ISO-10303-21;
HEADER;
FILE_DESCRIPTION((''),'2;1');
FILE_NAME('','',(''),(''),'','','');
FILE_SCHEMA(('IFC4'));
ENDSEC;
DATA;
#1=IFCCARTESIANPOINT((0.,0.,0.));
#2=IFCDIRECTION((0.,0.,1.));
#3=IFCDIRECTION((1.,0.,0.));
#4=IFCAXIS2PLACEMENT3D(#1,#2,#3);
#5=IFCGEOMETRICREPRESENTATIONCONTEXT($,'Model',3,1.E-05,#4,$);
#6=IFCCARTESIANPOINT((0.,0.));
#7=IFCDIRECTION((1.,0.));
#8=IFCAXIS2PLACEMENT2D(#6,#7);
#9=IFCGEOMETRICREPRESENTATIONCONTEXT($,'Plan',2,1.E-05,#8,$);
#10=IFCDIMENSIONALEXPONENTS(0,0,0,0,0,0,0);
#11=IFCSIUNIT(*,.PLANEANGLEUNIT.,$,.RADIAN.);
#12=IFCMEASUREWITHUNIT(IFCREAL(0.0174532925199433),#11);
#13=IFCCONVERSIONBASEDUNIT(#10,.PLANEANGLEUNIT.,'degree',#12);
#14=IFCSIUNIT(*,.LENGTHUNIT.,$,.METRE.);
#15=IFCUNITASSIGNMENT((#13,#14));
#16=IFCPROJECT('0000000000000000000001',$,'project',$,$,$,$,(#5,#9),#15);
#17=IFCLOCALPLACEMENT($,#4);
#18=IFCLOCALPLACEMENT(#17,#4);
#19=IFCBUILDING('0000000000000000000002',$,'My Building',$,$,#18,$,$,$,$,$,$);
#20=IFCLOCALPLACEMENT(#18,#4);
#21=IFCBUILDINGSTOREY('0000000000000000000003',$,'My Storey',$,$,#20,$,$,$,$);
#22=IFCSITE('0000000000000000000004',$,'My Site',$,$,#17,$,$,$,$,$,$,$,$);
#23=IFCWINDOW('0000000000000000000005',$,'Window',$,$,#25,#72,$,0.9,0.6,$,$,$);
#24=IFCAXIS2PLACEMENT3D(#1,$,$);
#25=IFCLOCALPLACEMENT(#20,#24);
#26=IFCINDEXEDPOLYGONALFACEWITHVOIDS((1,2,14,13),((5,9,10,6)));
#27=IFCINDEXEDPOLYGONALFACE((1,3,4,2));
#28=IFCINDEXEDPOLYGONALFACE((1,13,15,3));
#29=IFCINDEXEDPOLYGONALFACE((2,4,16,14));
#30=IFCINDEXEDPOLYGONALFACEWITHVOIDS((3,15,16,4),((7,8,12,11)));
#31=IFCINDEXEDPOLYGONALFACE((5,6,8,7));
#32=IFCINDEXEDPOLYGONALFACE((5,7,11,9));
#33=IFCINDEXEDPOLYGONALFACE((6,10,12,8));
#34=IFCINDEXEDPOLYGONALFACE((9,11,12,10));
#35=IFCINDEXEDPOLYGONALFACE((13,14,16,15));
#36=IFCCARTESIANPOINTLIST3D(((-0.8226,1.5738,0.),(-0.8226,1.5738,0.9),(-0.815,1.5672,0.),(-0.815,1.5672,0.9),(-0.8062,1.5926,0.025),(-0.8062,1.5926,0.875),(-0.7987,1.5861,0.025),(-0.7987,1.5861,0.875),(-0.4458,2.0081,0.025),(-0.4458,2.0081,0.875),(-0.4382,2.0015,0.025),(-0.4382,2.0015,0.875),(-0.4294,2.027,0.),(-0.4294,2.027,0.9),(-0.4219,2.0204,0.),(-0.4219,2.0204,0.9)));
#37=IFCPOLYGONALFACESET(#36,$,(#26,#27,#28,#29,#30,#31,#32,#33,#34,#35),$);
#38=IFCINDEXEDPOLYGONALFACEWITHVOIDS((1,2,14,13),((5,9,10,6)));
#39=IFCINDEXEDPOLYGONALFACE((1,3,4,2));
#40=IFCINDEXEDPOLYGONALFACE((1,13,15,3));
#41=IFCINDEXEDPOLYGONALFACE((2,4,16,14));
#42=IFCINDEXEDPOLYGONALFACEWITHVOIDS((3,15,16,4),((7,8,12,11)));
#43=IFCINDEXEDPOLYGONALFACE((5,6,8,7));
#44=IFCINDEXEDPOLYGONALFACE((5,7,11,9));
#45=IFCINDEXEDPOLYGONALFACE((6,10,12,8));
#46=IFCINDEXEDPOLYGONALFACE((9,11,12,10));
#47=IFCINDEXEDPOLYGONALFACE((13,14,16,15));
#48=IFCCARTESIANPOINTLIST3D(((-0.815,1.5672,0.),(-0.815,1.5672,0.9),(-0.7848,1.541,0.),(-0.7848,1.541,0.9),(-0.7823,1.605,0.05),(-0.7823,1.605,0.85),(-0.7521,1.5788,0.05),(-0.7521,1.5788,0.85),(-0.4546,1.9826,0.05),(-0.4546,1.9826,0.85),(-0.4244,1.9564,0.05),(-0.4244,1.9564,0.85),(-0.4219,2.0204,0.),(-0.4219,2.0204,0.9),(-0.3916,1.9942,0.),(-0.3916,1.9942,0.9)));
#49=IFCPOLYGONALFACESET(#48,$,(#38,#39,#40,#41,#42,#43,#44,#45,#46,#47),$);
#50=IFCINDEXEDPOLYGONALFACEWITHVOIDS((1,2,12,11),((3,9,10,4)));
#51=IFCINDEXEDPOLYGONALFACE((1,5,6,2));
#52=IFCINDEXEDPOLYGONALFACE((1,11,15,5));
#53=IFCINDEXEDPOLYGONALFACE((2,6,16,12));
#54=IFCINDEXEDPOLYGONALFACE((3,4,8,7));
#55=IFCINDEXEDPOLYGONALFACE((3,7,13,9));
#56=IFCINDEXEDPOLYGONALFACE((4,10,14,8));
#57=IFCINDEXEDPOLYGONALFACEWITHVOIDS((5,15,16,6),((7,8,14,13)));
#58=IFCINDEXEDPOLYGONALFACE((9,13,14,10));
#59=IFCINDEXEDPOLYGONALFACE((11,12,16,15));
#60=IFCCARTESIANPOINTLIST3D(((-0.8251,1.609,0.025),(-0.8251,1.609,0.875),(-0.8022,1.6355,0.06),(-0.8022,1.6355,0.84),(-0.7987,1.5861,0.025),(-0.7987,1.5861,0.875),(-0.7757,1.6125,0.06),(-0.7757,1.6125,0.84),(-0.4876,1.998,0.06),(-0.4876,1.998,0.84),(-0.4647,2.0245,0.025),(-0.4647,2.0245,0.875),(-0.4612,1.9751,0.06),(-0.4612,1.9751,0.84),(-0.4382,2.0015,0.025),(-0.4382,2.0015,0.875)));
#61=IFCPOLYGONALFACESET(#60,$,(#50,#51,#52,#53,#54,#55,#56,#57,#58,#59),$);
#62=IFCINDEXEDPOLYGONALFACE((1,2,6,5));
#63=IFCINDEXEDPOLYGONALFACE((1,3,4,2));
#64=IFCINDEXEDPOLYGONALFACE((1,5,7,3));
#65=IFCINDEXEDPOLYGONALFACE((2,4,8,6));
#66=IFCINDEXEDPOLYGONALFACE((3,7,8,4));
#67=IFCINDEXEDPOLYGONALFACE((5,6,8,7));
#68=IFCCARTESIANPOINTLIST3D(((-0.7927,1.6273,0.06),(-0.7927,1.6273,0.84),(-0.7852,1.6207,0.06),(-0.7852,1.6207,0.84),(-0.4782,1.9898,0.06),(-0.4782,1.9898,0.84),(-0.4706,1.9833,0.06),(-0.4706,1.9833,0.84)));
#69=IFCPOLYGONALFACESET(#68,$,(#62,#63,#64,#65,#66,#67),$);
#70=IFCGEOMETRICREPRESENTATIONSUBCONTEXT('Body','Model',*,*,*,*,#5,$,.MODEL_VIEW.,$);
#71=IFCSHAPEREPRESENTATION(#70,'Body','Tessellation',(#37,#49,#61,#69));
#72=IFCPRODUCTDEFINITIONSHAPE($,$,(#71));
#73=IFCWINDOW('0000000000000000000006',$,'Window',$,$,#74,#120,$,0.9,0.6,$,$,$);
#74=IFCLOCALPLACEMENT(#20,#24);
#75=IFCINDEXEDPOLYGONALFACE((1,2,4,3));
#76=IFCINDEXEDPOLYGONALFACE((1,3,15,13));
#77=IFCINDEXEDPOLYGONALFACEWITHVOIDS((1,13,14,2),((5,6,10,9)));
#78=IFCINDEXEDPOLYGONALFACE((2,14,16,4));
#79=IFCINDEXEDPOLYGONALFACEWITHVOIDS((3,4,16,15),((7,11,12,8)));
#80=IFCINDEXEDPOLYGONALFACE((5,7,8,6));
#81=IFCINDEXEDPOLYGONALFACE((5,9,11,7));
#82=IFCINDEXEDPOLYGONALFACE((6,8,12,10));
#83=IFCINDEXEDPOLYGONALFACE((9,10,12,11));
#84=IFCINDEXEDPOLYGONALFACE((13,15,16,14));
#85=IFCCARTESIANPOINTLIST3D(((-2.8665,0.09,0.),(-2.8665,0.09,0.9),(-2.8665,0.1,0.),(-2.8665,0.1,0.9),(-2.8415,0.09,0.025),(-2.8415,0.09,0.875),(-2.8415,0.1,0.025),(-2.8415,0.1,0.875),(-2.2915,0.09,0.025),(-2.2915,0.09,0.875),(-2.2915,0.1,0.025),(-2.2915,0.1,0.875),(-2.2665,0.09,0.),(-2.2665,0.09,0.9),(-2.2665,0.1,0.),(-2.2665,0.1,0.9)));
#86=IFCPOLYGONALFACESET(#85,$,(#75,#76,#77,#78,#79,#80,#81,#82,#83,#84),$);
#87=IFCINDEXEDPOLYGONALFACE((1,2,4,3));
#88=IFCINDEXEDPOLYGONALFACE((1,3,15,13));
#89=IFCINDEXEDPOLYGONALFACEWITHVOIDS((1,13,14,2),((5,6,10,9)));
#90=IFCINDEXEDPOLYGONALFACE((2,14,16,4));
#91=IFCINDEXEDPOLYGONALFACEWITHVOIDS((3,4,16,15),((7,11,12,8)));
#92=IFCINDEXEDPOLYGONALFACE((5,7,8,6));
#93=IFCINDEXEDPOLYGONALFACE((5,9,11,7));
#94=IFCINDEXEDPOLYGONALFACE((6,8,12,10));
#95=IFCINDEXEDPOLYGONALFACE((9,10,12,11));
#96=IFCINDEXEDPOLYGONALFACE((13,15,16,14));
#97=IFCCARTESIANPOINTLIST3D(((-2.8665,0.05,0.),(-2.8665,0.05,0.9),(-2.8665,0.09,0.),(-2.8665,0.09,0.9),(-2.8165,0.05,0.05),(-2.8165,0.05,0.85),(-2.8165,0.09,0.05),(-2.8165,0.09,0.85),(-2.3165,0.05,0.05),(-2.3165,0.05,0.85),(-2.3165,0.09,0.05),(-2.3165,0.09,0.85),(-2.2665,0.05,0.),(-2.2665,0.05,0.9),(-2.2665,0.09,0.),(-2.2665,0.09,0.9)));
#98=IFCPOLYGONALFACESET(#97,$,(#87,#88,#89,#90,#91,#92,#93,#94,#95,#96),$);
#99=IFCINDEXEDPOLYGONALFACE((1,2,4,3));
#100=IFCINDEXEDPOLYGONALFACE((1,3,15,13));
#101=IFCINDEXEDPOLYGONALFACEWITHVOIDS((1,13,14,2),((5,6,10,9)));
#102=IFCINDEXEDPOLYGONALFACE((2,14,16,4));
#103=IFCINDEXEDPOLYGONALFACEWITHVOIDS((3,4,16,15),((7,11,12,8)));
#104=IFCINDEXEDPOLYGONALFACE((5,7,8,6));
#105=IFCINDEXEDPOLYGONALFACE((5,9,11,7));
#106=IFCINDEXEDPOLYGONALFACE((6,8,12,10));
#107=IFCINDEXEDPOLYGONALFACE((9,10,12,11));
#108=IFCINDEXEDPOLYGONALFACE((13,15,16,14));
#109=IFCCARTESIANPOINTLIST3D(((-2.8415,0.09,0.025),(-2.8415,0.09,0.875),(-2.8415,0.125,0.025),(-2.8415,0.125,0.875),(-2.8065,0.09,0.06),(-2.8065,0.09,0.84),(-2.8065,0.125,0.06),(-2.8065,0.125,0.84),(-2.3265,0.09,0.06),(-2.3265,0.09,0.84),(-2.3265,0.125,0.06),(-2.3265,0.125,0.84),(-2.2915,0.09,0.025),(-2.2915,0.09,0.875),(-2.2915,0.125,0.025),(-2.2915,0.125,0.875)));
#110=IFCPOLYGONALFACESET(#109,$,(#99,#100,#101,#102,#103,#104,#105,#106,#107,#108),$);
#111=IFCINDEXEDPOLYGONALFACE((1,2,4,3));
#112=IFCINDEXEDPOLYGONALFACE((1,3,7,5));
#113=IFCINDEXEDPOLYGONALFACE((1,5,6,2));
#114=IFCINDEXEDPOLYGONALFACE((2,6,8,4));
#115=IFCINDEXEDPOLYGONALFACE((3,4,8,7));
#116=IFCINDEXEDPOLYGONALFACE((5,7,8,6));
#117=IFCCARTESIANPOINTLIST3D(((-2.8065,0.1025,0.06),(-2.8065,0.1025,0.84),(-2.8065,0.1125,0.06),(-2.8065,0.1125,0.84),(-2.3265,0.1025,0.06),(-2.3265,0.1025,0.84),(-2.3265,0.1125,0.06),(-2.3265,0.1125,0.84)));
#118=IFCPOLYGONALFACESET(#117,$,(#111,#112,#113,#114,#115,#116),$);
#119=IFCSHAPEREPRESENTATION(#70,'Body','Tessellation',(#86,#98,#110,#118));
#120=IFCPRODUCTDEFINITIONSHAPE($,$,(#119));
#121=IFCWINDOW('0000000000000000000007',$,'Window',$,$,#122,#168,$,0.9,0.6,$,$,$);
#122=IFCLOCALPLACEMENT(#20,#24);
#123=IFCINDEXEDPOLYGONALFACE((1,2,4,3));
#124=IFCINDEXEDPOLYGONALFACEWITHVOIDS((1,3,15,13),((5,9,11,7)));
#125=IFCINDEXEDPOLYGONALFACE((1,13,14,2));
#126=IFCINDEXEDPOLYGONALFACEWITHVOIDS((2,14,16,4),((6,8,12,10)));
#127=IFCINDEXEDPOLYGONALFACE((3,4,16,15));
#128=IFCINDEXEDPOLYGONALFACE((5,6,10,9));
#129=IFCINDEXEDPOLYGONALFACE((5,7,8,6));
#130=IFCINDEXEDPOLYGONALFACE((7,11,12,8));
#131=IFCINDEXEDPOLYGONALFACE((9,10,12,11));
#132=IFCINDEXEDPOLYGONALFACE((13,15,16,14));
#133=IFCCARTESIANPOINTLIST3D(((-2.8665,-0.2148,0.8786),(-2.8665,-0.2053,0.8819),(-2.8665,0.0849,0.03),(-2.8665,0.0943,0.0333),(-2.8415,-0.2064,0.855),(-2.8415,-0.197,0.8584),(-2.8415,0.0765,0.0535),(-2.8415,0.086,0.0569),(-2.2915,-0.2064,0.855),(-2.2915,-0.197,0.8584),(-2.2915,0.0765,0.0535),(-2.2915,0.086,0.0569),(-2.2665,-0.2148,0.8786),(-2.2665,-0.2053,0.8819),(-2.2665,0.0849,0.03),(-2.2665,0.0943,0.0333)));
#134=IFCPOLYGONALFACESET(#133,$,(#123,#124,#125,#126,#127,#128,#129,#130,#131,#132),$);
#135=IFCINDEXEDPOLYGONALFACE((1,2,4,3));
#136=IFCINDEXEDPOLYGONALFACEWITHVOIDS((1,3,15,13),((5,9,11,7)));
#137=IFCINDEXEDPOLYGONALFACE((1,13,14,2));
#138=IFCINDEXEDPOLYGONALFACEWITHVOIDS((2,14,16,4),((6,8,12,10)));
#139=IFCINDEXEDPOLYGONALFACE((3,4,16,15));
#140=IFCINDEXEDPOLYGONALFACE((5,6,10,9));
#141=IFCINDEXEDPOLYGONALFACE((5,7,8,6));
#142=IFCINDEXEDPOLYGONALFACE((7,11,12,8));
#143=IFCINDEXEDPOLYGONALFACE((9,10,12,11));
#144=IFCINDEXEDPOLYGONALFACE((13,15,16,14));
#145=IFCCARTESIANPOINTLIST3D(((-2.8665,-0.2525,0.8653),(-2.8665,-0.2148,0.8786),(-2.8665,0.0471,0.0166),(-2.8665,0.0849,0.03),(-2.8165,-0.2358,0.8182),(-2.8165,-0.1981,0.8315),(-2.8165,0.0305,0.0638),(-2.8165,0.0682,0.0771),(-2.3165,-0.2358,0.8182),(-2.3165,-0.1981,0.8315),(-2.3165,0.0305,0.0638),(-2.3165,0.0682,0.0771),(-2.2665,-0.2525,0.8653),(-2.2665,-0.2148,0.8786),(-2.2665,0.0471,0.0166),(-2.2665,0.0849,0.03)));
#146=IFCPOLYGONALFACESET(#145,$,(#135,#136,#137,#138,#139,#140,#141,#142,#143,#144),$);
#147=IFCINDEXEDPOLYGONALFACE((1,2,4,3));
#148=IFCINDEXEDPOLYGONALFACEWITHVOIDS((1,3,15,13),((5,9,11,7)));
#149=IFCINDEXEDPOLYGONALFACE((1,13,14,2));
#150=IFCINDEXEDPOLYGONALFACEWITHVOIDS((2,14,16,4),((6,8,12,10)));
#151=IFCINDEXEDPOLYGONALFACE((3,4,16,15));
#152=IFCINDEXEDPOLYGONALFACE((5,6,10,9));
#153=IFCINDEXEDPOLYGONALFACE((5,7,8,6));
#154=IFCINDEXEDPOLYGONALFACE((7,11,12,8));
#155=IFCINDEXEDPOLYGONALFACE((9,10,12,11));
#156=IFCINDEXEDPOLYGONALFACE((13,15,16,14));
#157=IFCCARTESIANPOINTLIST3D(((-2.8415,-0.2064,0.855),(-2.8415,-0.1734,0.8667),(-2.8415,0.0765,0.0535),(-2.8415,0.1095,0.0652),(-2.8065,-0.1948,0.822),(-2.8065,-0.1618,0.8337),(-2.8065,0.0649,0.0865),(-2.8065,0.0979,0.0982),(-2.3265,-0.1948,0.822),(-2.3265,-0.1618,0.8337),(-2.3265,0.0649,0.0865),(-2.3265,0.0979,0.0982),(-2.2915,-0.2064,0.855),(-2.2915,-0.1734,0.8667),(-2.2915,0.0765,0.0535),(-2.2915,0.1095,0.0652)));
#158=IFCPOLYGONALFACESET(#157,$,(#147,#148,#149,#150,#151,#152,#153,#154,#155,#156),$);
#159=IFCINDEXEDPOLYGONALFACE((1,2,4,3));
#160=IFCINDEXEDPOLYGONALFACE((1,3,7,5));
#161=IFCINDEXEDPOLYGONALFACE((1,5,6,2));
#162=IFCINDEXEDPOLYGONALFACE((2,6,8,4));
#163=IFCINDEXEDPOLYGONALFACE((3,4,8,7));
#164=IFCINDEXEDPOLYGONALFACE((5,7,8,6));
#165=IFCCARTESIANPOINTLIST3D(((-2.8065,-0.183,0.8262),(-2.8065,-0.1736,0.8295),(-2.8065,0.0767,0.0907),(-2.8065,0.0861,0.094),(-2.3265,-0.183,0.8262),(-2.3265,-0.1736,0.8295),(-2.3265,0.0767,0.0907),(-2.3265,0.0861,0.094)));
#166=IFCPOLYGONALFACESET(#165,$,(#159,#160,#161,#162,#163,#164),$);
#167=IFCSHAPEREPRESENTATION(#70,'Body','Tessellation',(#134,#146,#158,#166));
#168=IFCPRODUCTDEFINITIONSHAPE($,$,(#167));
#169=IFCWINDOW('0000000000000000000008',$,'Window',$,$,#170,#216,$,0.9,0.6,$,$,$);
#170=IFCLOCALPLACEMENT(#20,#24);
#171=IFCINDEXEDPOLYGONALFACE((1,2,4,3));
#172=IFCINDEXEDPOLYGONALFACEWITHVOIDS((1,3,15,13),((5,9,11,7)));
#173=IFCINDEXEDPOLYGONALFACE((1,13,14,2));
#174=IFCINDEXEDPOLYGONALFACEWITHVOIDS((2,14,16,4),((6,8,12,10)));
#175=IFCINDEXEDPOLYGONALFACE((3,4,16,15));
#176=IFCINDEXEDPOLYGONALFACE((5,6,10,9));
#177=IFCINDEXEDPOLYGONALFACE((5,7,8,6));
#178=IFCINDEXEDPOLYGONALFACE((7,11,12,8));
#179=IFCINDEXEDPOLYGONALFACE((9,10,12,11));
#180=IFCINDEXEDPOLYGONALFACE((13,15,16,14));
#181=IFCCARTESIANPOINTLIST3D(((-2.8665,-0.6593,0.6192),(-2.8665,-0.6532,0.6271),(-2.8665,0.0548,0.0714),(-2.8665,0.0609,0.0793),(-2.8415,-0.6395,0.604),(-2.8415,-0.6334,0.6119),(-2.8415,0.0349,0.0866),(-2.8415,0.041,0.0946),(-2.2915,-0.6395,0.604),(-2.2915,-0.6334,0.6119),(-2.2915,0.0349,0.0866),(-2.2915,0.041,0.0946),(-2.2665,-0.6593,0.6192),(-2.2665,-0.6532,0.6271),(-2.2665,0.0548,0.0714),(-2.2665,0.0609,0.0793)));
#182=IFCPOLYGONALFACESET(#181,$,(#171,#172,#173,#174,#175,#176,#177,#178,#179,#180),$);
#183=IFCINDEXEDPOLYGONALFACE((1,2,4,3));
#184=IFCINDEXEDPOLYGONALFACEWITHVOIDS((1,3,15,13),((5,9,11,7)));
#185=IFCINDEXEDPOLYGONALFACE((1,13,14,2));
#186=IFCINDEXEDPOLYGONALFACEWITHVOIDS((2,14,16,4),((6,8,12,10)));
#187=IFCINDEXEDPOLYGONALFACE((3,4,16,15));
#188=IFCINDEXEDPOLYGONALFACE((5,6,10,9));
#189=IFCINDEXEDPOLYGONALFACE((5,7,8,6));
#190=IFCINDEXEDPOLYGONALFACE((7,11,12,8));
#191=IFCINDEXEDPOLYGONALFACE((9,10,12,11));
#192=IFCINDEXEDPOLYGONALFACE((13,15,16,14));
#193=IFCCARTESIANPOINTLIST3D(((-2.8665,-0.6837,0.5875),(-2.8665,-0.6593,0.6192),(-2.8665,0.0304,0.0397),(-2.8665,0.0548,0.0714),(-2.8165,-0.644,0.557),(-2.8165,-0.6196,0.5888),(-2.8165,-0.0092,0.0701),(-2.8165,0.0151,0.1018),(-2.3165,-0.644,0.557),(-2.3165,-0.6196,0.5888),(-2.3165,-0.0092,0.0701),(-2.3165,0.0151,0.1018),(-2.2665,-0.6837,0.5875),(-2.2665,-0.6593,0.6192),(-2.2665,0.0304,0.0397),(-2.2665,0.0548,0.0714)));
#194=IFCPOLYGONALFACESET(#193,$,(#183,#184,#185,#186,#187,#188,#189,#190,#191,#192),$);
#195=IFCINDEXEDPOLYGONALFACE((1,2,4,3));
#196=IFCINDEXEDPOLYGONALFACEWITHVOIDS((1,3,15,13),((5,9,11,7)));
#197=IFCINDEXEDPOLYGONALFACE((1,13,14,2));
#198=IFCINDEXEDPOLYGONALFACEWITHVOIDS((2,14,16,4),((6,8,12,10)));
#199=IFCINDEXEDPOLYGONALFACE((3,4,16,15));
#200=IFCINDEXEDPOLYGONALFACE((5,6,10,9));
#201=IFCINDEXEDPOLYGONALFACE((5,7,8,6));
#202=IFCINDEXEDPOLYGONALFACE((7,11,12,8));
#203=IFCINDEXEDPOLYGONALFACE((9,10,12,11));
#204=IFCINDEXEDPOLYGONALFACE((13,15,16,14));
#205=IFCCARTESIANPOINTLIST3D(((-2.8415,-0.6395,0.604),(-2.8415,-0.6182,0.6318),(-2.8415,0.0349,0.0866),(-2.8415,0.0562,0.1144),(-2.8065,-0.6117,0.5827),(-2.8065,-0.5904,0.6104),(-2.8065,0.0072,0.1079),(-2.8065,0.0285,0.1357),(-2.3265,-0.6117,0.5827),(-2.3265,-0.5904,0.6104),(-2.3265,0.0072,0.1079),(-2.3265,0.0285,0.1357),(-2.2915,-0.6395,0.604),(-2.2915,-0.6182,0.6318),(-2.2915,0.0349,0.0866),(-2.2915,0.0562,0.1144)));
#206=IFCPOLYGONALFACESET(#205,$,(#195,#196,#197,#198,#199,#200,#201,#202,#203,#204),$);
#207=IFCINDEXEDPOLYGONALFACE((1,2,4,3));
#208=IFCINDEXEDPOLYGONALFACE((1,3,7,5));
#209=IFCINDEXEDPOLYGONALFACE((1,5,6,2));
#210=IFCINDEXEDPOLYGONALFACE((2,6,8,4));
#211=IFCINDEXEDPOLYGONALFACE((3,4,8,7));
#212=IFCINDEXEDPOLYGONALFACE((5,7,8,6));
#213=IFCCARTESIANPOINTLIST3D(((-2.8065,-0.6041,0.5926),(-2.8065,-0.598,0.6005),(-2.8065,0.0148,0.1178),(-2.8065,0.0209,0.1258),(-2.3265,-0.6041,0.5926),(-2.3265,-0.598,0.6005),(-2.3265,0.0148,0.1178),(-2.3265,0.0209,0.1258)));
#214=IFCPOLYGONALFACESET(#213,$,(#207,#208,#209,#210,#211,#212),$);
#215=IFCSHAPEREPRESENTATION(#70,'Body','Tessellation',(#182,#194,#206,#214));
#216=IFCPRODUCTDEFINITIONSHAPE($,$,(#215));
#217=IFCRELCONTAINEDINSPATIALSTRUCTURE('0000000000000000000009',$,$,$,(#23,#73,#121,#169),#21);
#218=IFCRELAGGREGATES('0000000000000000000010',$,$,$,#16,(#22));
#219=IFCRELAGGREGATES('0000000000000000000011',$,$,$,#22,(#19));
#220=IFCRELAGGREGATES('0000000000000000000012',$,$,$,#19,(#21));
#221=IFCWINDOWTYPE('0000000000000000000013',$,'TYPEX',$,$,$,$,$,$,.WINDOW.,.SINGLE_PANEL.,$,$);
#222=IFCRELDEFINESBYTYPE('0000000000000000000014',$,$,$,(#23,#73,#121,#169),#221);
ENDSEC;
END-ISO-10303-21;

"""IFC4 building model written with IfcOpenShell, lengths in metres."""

from ifc_helpers import new_model, entity, si_unit, converted_unit, frame, origin_with_axes, origin_2d_with_axis, place, context, subcontext, project, spatial, line, indexed_curve, outline, extrude, shape, source, transform, mapped, type_object, type_shapes, element, save


model = new_model("IFC4")

# Units and contexts
model_context = context("Model", 3, precision=1e-05, world=origin_with_axes())
plan_context = context("Plan", 2, precision=1e-05, world=origin_2d_with_axis())
body_context_1 = subcontext(model_context, "Body", "Model", "MODEL_VIEW")
body_context_2 = subcontext(plan_context, "Body", "Plan", "PLAN_VIEW")
ifc_project = project(units=[converted_unit("PLANEANGLEUNIT", "degree", entity("IfcReal", 0.0174532925199433), si_unit("PLANEANGLEUNIT", "RADIAN"), dimensions=[0, 0, 0, 0, 0, 0, 0]), si_unit("LENGTHUNIT", "METRE")], contexts=[model_context, plan_context])

# Site, building, storey
site_placement = place(None, origin_with_axes())
site = spatial("IfcSite", under=ifc_project, at=site_placement, Name="My Site")
building_placement = place(site_placement, origin_with_axes())
building = spatial("IfcBuilding", under=site, at=building_placement, Name="My Building")
storey_placement = place(building_placement, origin_with_axes())
storey = spatial("IfcBuildingStorey", under=building, at=storey_placement, Name="My Storey")

# Windows
window_type = type_object("IfcWindowType", Name="TYPEX", PartitioningType="SINGLE_PANEL", PredefinedType="WINDOW")
shared_shape_1 = source(origin_with_axes(), body_context_1, "Body", "SweptSolid", [
    extrude(outline(indexed_curve([(0.0, 0.0), (0.6, 0.0), (0.6, 0.9), (0.0, 0.9)], segments=[line(1, 2, 3, 4, 1)]), holes=[indexed_curve([(0.025, 0.025), (0.575, 0.025), (0.575, 0.875), (0.025, 0.875)], segments=[line(1, 2, 3, 4, 1)])]), frame((0.0, 0.09, 0.0), z_axis=(0.0, -1.0, 0.0), x_axis=(1.0, 0.0, 0.0)), (0.0, 0.0, -1.0), 0.01),
    extrude(outline(indexed_curve([(0.0, 0.0), (0.6, 0.0), (0.6, 0.9), (0.0, 0.9)], segments=[line(1, 2, 3, 4, 1)]), holes=[indexed_curve([(0.05, 0.05), (0.55, 0.05), (0.55, 0.85), (0.05, 0.85)], segments=[line(1, 2, 3, 4, 1)])]), frame((0.0, 0.05, 0.0), z_axis=(0.0, -1.0, 0.0), x_axis=(1.0, 0.0, 0.0)), (0.0, 0.0, -1.0), 0.04),
    extrude(outline(indexed_curve([(0.0, 0.0), (0.55, 0.0), (0.55, 0.85), (0.0, 0.85)], segments=[line(1, 2, 3, 4, 1)]), holes=[indexed_curve([(0.035, 0.035), (0.515, 0.035), (0.515, 0.815), (0.035, 0.815)], segments=[line(1, 2, 3, 4, 1)])]), frame((0.025, 0.09, 0.025), z_axis=(0.0, -1.0, 0.0), x_axis=(1.0, 0.0, 0.0)), (0.0, 0.0, -1.0), 0.035),
    extrude(outline(indexed_curve([(0.035, 0.035), (0.515, 0.035), (0.515, 0.815), (0.035, 0.815)], segments=[line(1, 2, 3, 4, 1)])), frame((0.025, 0.1025, 0.025), z_axis=(0.0, -1.0, 0.0), x_axis=(1.0, 0.0, 0.0)), (0.0, 0.0, -1.0), 0.01),
])
shared_shape_2 = source(origin_with_axes(), body_context_2, "Body", "Curve2D", [
    entity("IfcIndexedPolyCurve", entity("IfcCartesianPointList2D", [[0.05, 0.05], [0.55, 0.05]])),
    entity("IfcIndexedPolyCurve", entity("IfcCartesianPointList2D", [[0.0, 0.1], [0.025, 0.1], [0.025, 0.09], [0.05, 0.09], [0.05, 0.05], [0.0, 0.05]]), [entity("IfcLineIndex", [1, 2, 3, 4, 5, 6, 1])]),
    entity("IfcIndexedPolyCurve", entity("IfcCartesianPointList2D", [[0.6, 0.1], [0.575, 0.1], [0.575, 0.09], [0.55, 0.09], [0.55, 0.05], [0.6, 0.05]]), [entity("IfcLineIndex", [1, 2, 3, 4, 5, 6, 1])]),
    entity("IfcIndexedPolyCurve", entity("IfcCartesianPointList2D", [[0.025, 0.09], [0.06, 0.09], [0.06, 0.125], [0.025, 0.125]]), [entity("IfcLineIndex", [1, 2, 3, 4, 1])]),
    entity("IfcIndexedPolyCurve", entity("IfcCartesianPointList2D", [[0.575, 0.09], [0.54, 0.09], [0.54, 0.125], [0.575, 0.125]]), [entity("IfcLineIndex", [1, 2, 3, 4, 1])]),
    entity("IfcIndexedPolyCurve", entity("IfcCartesianPointList2D", [[0.06, 0.09], [0.54, 0.09]])),
    entity("IfcIndexedPolyCurve", entity("IfcCartesianPointList2D", [[0.06, 0.125], [0.54, 0.125]])),
    entity("IfcIndexedPolyCurve", entity("IfcCartesianPointList2D", [[0.06, 0.1075], [0.54, 0.1075]])),
])
type_shapes(window_type, [shared_shape_1, shared_shape_2])
for number, where, z_axis, x_axis, name in (
    (1, (-0.7471, 1.5082, 0.0), (0.0, 0.0, 1.0), (0.655319, 0.755352, 0.0), "Window"),
    (2, (-2.8665, 0.0, 0.0), (0.0, 0.0, 1.0), (1.0, 0.0, 0.0), "Window"),
    (3, (-2.8665, 0.0, 0.0), (0.0, -0.332927, 0.942952), (1.0, 0.0, 0.0), "Window"),
    (4, (-2.8665, 0.0, 0.0), (0.0, -0.793436, 0.608653), (1.0, 0.0, 0.0), "Window"),
):
    element("IfcWindow", number, at=place(storey_placement, frame(where, z_axis=z_axis, x_axis=x_axis)), inside=storey, type_object=window_type, Name=name, OverallHeight=0.9, OverallWidth=0.6, shapes=[
        shape(body_context_1, "Body", "MappedRepresentation", [mapped(shared_shape_1, transform((0.0, 0.0, 0.0), x_axis=(1.0, 0.0, 0.0), y_axis=(0.0, 1.0, 0.0), z_axis=(0.0, 0.0, 1.0), scale=1.0))]),
        shape(body_context_2, "Body", "MappedRepresentation", [mapped(shared_shape_2, transform((0.0, 0.0, 0.0), x_axis=(1.0, 0.0, 0.0), y_axis=(0.0, 1.0, 0.0), z_axis=(0.0, 0.0, 1.0), scale=1.0))]),
    ])

save(model, "model.ifc")
